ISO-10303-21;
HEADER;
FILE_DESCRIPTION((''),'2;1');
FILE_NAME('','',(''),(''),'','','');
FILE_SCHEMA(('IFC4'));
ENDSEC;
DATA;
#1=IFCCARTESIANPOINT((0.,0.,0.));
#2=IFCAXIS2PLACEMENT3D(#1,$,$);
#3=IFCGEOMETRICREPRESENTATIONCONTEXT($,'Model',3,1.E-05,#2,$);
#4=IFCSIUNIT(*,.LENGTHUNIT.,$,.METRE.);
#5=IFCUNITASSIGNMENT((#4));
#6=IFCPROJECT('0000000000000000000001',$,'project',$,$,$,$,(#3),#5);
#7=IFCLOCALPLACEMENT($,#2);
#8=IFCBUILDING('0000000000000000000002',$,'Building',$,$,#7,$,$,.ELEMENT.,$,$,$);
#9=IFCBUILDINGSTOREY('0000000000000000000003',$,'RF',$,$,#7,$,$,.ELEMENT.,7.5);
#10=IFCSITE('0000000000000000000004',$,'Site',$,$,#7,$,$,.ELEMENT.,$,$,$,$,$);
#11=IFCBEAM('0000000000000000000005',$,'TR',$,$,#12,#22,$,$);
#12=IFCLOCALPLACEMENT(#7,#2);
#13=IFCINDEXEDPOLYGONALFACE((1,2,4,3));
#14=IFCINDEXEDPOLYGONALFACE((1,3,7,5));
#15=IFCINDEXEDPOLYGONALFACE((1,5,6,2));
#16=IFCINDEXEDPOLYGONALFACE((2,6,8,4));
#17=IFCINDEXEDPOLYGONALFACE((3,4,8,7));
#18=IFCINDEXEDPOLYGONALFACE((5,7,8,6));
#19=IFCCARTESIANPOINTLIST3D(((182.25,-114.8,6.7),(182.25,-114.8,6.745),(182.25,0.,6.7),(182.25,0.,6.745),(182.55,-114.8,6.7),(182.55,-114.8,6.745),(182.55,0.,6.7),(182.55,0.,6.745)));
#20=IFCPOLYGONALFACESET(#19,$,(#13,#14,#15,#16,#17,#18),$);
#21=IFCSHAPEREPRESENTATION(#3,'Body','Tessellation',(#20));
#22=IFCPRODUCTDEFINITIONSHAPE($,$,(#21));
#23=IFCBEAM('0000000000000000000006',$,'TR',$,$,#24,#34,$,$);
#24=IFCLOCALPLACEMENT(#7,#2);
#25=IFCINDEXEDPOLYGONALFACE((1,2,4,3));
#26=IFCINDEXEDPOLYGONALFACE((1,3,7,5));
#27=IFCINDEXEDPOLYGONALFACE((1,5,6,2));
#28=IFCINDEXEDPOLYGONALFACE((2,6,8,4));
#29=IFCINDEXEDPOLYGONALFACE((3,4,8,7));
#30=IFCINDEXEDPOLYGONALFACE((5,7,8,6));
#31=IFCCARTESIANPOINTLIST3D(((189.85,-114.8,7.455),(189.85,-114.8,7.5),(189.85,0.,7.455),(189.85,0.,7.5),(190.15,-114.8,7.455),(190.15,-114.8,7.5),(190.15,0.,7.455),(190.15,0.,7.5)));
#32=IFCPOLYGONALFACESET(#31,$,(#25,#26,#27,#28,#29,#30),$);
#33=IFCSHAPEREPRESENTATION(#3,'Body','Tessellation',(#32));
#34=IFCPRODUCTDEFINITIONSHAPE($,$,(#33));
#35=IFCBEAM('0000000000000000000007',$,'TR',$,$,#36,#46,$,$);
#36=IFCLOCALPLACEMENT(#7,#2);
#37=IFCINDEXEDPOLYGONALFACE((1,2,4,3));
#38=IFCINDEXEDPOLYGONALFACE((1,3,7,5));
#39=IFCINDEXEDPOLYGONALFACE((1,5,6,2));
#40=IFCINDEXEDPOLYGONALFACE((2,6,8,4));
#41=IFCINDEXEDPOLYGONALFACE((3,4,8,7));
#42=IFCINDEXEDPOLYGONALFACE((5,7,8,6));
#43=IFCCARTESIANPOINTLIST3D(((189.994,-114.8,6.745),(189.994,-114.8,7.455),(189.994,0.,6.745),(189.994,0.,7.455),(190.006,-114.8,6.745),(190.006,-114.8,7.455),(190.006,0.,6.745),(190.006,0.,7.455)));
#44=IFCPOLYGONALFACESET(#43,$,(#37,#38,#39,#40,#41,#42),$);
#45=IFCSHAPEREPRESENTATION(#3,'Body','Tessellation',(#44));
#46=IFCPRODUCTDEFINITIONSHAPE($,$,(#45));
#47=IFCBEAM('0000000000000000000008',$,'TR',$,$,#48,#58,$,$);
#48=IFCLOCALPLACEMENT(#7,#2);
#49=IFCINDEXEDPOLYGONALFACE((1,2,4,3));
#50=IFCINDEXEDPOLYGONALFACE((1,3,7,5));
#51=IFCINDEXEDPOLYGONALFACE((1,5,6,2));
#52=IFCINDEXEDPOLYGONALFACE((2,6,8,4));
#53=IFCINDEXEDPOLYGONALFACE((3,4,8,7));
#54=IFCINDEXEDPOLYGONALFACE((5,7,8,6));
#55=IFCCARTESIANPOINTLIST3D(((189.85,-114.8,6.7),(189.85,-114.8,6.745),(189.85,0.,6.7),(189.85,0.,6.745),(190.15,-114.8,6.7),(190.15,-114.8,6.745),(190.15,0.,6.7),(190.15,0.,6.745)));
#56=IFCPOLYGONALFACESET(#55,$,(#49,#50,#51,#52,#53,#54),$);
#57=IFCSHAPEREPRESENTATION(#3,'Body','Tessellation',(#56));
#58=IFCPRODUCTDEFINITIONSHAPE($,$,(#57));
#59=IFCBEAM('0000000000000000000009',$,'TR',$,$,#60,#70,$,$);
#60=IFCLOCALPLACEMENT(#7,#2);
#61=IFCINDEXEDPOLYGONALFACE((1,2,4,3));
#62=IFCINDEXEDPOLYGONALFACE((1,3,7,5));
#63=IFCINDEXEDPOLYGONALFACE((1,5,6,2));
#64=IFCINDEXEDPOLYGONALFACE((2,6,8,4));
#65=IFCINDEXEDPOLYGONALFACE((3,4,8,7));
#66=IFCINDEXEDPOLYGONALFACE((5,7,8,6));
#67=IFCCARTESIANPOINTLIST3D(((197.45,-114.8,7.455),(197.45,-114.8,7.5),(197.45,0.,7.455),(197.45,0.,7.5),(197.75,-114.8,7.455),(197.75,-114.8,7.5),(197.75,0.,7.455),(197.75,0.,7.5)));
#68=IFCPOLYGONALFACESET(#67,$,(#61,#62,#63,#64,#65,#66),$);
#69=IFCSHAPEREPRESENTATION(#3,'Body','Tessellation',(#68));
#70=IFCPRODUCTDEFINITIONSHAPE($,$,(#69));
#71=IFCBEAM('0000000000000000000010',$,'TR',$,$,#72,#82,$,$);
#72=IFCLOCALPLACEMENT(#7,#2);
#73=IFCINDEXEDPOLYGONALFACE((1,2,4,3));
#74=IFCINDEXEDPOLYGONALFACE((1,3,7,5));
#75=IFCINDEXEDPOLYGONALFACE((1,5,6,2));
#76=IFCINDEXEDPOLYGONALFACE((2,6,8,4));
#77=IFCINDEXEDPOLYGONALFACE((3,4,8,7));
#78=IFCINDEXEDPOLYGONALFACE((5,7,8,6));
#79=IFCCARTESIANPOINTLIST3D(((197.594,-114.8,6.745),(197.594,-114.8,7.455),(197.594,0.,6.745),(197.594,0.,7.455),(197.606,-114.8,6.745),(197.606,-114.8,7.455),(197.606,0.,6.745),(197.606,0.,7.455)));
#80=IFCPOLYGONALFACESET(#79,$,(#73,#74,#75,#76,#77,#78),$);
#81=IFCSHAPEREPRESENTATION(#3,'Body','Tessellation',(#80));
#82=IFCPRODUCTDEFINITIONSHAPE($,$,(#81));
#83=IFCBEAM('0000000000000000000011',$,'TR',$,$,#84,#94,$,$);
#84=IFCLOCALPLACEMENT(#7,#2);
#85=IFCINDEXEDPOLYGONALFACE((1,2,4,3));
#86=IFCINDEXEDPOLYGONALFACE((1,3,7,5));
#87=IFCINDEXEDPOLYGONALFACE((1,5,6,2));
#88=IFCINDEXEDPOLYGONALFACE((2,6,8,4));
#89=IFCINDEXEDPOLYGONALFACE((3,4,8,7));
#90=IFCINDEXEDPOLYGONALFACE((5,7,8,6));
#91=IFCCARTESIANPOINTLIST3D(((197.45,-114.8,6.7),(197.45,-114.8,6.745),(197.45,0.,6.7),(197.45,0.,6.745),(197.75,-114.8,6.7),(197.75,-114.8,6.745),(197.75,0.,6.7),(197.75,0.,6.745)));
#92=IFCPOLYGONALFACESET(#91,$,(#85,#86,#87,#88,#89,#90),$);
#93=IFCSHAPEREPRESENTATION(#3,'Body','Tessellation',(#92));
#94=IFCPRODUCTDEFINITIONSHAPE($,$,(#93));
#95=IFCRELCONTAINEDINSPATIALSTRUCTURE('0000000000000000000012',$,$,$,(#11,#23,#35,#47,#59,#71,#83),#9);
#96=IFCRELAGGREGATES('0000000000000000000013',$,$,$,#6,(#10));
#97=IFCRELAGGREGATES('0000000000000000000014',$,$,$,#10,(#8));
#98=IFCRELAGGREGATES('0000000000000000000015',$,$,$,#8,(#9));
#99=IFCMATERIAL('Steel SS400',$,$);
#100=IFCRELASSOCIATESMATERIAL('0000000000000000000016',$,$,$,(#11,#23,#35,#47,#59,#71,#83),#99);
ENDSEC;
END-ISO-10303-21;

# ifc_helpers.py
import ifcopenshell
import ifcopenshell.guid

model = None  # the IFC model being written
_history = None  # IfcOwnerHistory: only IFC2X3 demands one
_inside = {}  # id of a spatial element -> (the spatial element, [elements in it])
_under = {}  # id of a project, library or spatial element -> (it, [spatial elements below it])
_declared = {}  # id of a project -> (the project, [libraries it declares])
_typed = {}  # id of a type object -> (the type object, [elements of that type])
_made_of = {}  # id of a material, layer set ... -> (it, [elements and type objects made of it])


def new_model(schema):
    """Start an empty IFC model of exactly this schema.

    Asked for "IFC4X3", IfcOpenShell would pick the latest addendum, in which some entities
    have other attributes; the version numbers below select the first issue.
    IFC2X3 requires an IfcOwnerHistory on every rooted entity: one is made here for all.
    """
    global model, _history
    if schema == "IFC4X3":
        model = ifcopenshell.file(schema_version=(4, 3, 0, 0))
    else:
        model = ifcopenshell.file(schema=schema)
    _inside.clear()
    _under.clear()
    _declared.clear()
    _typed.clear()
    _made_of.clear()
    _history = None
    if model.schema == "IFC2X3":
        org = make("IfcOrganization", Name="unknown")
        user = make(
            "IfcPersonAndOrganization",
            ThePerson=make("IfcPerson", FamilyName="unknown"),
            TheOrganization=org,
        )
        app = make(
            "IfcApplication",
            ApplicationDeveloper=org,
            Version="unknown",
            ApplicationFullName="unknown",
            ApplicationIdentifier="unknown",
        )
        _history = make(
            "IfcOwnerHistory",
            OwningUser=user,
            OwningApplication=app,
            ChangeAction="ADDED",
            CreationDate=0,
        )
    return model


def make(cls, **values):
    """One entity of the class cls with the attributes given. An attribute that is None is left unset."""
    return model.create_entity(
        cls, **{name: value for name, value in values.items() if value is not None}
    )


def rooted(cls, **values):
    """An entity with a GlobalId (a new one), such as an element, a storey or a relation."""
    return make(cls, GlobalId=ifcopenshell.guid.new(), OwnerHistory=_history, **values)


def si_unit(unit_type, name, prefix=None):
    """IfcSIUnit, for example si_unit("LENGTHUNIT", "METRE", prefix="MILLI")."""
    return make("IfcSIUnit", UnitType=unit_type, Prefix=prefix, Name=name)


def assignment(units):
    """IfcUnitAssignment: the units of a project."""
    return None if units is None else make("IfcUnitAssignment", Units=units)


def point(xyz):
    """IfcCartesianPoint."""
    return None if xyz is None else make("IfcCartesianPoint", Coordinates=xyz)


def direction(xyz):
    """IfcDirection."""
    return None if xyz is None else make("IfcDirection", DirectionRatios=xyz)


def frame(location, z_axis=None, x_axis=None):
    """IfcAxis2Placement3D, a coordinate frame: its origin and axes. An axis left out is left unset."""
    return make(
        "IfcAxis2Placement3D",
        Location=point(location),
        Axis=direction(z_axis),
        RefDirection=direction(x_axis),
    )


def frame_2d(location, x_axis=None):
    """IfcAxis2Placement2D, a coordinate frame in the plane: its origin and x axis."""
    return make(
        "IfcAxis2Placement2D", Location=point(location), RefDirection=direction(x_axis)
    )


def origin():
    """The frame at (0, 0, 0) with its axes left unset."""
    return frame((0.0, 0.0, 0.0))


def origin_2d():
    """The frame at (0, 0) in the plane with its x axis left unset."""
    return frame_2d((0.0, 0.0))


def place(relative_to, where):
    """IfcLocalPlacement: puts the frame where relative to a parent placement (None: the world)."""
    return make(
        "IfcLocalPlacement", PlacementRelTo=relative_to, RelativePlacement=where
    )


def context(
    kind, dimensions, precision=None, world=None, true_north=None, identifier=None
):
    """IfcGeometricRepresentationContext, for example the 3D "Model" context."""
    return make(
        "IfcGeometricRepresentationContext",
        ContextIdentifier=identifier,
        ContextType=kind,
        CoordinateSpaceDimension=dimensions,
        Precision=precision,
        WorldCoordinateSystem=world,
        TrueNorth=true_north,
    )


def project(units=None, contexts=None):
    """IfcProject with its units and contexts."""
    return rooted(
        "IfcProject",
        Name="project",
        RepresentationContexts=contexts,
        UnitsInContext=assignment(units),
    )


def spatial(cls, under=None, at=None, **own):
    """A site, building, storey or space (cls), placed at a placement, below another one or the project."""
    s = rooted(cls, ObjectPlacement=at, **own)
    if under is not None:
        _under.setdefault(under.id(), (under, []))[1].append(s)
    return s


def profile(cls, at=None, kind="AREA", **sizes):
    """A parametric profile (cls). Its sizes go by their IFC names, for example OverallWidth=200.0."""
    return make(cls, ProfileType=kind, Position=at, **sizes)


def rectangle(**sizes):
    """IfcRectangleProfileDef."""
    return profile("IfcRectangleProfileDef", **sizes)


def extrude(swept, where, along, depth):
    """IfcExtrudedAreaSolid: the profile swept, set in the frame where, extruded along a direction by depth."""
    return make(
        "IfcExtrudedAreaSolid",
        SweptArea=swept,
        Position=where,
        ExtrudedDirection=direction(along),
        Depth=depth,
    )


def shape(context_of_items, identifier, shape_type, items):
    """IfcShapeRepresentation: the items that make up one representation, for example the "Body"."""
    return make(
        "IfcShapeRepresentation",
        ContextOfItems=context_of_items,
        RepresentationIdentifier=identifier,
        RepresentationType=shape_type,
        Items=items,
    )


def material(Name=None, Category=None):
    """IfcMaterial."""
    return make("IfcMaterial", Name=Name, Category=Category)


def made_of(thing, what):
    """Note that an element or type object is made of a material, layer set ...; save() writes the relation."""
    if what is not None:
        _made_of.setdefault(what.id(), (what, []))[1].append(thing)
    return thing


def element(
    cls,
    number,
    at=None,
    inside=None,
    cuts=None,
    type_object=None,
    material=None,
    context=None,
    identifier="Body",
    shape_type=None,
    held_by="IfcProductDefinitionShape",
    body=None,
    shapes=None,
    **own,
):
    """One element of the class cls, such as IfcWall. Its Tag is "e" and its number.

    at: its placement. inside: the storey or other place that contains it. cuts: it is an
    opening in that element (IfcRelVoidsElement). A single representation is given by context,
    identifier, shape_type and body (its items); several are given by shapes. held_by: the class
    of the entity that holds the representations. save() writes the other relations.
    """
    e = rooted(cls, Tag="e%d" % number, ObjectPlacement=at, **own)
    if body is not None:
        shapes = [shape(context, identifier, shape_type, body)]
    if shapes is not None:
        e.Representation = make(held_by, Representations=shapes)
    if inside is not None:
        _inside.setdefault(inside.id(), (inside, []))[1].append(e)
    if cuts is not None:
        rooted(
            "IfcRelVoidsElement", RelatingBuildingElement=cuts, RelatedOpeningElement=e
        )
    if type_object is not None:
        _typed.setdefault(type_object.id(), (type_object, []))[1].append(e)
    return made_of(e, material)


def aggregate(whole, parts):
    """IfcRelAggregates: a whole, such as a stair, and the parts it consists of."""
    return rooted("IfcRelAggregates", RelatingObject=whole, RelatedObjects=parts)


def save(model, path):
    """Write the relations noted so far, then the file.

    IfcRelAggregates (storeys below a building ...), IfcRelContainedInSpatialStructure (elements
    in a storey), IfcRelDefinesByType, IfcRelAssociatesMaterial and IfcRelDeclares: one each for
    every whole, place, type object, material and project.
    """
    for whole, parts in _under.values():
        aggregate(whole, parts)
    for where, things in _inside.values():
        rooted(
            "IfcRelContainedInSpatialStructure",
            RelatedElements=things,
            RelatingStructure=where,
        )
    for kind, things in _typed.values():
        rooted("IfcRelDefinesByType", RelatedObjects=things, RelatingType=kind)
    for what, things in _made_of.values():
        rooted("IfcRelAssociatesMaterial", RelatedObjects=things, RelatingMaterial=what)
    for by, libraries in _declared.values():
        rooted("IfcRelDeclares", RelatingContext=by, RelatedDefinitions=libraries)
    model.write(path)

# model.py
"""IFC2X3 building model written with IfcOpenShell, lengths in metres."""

from ifc_helpers import new_model, si_unit, frame, origin, origin_2d, place, context, project, spatial, rectangle, extrude, material, element, save


model = new_model("IFC2X3")

# Units and contexts
model_context = context("Model", 3, precision=1e-05, world=origin())
ifc_project = project(units=[si_unit("LENGTHUNIT", "METRE")], contexts=[model_context])

# Site, building, storey
placement = place(None, origin())
site = spatial("IfcSite", under=ifc_project, at=placement, Name="Site", CompositionType="ELEMENT")
building = spatial("IfcBuilding", under=site, at=placement, Name="Building", CompositionType="ELEMENT")
storey = spatial("IfcBuildingStorey", under=building, at=placement, Name="RF", CompositionType="ELEMENT", Elevation=7.5)

# Beams
ifc_material = material(Name="Steel SS400")
for number, where, name in (
    (1, (182.4, -57.4, 6.7), "TR"),
    (2, (190.0, -57.4, 7.455), "TR"),
):
    element("IfcBeam", number, at=place(None, frame(where)), inside=storey, material=ifc_material, Name=name, context=model_context, shape_type="SweptSolid", body=[
        extrude(rectangle(XDim=0.3, YDim=114.8, at=origin_2d()), origin(), (0.0, 0.0, 1.0), 0.045),
    ])
beam_1_placement = place(None, frame((190.0, -57.4, 6.745)))
element("IfcBeam", 3, at=beam_1_placement, inside=storey, material=ifc_material, Name="TR", context=model_context, shape_type="SweptSolid", body=[
    extrude(rectangle(XDim=0.012, YDim=114.8, at=origin_2d()), origin(), (0.0, 0.0, 1.0), 0.71),
])
for number, where, name in (
    (4, (190.0, -57.4, 6.7), "TR"),
    (5, (197.6, -57.4, 7.455), "TR"),
):
    element("IfcBeam", number, at=place(None, frame(where)), inside=storey, material=ifc_material, Name=name, context=model_context, shape_type="SweptSolid", body=[
        extrude(rectangle(XDim=0.3, YDim=114.8, at=origin_2d()), origin(), (0.0, 0.0, 1.0), 0.045),
    ])
beam_2_placement = place(None, frame((197.6, -57.4, 6.745)))
element("IfcBeam", 6, at=beam_2_placement, inside=storey, material=ifc_material, Name="TR", context=model_context, shape_type="SweptSolid", body=[
    extrude(rectangle(XDim=0.012, YDim=114.8, at=origin_2d()), origin(), (0.0, 0.0, 1.0), 0.71),
])
beam_3_placement = place(None, frame((197.6, -57.4, 6.7)))
element("IfcBeam", 7, at=beam_3_placement, inside=storey, material=ifc_material, Name="TR", context=model_context, shape_type="SweptSolid", body=[
    extrude(rectangle(XDim=0.3, YDim=114.8, at=origin_2d()), origin(), (0.0, 0.0, 1.0), 0.045),
])

save(model, "model.ifc")
